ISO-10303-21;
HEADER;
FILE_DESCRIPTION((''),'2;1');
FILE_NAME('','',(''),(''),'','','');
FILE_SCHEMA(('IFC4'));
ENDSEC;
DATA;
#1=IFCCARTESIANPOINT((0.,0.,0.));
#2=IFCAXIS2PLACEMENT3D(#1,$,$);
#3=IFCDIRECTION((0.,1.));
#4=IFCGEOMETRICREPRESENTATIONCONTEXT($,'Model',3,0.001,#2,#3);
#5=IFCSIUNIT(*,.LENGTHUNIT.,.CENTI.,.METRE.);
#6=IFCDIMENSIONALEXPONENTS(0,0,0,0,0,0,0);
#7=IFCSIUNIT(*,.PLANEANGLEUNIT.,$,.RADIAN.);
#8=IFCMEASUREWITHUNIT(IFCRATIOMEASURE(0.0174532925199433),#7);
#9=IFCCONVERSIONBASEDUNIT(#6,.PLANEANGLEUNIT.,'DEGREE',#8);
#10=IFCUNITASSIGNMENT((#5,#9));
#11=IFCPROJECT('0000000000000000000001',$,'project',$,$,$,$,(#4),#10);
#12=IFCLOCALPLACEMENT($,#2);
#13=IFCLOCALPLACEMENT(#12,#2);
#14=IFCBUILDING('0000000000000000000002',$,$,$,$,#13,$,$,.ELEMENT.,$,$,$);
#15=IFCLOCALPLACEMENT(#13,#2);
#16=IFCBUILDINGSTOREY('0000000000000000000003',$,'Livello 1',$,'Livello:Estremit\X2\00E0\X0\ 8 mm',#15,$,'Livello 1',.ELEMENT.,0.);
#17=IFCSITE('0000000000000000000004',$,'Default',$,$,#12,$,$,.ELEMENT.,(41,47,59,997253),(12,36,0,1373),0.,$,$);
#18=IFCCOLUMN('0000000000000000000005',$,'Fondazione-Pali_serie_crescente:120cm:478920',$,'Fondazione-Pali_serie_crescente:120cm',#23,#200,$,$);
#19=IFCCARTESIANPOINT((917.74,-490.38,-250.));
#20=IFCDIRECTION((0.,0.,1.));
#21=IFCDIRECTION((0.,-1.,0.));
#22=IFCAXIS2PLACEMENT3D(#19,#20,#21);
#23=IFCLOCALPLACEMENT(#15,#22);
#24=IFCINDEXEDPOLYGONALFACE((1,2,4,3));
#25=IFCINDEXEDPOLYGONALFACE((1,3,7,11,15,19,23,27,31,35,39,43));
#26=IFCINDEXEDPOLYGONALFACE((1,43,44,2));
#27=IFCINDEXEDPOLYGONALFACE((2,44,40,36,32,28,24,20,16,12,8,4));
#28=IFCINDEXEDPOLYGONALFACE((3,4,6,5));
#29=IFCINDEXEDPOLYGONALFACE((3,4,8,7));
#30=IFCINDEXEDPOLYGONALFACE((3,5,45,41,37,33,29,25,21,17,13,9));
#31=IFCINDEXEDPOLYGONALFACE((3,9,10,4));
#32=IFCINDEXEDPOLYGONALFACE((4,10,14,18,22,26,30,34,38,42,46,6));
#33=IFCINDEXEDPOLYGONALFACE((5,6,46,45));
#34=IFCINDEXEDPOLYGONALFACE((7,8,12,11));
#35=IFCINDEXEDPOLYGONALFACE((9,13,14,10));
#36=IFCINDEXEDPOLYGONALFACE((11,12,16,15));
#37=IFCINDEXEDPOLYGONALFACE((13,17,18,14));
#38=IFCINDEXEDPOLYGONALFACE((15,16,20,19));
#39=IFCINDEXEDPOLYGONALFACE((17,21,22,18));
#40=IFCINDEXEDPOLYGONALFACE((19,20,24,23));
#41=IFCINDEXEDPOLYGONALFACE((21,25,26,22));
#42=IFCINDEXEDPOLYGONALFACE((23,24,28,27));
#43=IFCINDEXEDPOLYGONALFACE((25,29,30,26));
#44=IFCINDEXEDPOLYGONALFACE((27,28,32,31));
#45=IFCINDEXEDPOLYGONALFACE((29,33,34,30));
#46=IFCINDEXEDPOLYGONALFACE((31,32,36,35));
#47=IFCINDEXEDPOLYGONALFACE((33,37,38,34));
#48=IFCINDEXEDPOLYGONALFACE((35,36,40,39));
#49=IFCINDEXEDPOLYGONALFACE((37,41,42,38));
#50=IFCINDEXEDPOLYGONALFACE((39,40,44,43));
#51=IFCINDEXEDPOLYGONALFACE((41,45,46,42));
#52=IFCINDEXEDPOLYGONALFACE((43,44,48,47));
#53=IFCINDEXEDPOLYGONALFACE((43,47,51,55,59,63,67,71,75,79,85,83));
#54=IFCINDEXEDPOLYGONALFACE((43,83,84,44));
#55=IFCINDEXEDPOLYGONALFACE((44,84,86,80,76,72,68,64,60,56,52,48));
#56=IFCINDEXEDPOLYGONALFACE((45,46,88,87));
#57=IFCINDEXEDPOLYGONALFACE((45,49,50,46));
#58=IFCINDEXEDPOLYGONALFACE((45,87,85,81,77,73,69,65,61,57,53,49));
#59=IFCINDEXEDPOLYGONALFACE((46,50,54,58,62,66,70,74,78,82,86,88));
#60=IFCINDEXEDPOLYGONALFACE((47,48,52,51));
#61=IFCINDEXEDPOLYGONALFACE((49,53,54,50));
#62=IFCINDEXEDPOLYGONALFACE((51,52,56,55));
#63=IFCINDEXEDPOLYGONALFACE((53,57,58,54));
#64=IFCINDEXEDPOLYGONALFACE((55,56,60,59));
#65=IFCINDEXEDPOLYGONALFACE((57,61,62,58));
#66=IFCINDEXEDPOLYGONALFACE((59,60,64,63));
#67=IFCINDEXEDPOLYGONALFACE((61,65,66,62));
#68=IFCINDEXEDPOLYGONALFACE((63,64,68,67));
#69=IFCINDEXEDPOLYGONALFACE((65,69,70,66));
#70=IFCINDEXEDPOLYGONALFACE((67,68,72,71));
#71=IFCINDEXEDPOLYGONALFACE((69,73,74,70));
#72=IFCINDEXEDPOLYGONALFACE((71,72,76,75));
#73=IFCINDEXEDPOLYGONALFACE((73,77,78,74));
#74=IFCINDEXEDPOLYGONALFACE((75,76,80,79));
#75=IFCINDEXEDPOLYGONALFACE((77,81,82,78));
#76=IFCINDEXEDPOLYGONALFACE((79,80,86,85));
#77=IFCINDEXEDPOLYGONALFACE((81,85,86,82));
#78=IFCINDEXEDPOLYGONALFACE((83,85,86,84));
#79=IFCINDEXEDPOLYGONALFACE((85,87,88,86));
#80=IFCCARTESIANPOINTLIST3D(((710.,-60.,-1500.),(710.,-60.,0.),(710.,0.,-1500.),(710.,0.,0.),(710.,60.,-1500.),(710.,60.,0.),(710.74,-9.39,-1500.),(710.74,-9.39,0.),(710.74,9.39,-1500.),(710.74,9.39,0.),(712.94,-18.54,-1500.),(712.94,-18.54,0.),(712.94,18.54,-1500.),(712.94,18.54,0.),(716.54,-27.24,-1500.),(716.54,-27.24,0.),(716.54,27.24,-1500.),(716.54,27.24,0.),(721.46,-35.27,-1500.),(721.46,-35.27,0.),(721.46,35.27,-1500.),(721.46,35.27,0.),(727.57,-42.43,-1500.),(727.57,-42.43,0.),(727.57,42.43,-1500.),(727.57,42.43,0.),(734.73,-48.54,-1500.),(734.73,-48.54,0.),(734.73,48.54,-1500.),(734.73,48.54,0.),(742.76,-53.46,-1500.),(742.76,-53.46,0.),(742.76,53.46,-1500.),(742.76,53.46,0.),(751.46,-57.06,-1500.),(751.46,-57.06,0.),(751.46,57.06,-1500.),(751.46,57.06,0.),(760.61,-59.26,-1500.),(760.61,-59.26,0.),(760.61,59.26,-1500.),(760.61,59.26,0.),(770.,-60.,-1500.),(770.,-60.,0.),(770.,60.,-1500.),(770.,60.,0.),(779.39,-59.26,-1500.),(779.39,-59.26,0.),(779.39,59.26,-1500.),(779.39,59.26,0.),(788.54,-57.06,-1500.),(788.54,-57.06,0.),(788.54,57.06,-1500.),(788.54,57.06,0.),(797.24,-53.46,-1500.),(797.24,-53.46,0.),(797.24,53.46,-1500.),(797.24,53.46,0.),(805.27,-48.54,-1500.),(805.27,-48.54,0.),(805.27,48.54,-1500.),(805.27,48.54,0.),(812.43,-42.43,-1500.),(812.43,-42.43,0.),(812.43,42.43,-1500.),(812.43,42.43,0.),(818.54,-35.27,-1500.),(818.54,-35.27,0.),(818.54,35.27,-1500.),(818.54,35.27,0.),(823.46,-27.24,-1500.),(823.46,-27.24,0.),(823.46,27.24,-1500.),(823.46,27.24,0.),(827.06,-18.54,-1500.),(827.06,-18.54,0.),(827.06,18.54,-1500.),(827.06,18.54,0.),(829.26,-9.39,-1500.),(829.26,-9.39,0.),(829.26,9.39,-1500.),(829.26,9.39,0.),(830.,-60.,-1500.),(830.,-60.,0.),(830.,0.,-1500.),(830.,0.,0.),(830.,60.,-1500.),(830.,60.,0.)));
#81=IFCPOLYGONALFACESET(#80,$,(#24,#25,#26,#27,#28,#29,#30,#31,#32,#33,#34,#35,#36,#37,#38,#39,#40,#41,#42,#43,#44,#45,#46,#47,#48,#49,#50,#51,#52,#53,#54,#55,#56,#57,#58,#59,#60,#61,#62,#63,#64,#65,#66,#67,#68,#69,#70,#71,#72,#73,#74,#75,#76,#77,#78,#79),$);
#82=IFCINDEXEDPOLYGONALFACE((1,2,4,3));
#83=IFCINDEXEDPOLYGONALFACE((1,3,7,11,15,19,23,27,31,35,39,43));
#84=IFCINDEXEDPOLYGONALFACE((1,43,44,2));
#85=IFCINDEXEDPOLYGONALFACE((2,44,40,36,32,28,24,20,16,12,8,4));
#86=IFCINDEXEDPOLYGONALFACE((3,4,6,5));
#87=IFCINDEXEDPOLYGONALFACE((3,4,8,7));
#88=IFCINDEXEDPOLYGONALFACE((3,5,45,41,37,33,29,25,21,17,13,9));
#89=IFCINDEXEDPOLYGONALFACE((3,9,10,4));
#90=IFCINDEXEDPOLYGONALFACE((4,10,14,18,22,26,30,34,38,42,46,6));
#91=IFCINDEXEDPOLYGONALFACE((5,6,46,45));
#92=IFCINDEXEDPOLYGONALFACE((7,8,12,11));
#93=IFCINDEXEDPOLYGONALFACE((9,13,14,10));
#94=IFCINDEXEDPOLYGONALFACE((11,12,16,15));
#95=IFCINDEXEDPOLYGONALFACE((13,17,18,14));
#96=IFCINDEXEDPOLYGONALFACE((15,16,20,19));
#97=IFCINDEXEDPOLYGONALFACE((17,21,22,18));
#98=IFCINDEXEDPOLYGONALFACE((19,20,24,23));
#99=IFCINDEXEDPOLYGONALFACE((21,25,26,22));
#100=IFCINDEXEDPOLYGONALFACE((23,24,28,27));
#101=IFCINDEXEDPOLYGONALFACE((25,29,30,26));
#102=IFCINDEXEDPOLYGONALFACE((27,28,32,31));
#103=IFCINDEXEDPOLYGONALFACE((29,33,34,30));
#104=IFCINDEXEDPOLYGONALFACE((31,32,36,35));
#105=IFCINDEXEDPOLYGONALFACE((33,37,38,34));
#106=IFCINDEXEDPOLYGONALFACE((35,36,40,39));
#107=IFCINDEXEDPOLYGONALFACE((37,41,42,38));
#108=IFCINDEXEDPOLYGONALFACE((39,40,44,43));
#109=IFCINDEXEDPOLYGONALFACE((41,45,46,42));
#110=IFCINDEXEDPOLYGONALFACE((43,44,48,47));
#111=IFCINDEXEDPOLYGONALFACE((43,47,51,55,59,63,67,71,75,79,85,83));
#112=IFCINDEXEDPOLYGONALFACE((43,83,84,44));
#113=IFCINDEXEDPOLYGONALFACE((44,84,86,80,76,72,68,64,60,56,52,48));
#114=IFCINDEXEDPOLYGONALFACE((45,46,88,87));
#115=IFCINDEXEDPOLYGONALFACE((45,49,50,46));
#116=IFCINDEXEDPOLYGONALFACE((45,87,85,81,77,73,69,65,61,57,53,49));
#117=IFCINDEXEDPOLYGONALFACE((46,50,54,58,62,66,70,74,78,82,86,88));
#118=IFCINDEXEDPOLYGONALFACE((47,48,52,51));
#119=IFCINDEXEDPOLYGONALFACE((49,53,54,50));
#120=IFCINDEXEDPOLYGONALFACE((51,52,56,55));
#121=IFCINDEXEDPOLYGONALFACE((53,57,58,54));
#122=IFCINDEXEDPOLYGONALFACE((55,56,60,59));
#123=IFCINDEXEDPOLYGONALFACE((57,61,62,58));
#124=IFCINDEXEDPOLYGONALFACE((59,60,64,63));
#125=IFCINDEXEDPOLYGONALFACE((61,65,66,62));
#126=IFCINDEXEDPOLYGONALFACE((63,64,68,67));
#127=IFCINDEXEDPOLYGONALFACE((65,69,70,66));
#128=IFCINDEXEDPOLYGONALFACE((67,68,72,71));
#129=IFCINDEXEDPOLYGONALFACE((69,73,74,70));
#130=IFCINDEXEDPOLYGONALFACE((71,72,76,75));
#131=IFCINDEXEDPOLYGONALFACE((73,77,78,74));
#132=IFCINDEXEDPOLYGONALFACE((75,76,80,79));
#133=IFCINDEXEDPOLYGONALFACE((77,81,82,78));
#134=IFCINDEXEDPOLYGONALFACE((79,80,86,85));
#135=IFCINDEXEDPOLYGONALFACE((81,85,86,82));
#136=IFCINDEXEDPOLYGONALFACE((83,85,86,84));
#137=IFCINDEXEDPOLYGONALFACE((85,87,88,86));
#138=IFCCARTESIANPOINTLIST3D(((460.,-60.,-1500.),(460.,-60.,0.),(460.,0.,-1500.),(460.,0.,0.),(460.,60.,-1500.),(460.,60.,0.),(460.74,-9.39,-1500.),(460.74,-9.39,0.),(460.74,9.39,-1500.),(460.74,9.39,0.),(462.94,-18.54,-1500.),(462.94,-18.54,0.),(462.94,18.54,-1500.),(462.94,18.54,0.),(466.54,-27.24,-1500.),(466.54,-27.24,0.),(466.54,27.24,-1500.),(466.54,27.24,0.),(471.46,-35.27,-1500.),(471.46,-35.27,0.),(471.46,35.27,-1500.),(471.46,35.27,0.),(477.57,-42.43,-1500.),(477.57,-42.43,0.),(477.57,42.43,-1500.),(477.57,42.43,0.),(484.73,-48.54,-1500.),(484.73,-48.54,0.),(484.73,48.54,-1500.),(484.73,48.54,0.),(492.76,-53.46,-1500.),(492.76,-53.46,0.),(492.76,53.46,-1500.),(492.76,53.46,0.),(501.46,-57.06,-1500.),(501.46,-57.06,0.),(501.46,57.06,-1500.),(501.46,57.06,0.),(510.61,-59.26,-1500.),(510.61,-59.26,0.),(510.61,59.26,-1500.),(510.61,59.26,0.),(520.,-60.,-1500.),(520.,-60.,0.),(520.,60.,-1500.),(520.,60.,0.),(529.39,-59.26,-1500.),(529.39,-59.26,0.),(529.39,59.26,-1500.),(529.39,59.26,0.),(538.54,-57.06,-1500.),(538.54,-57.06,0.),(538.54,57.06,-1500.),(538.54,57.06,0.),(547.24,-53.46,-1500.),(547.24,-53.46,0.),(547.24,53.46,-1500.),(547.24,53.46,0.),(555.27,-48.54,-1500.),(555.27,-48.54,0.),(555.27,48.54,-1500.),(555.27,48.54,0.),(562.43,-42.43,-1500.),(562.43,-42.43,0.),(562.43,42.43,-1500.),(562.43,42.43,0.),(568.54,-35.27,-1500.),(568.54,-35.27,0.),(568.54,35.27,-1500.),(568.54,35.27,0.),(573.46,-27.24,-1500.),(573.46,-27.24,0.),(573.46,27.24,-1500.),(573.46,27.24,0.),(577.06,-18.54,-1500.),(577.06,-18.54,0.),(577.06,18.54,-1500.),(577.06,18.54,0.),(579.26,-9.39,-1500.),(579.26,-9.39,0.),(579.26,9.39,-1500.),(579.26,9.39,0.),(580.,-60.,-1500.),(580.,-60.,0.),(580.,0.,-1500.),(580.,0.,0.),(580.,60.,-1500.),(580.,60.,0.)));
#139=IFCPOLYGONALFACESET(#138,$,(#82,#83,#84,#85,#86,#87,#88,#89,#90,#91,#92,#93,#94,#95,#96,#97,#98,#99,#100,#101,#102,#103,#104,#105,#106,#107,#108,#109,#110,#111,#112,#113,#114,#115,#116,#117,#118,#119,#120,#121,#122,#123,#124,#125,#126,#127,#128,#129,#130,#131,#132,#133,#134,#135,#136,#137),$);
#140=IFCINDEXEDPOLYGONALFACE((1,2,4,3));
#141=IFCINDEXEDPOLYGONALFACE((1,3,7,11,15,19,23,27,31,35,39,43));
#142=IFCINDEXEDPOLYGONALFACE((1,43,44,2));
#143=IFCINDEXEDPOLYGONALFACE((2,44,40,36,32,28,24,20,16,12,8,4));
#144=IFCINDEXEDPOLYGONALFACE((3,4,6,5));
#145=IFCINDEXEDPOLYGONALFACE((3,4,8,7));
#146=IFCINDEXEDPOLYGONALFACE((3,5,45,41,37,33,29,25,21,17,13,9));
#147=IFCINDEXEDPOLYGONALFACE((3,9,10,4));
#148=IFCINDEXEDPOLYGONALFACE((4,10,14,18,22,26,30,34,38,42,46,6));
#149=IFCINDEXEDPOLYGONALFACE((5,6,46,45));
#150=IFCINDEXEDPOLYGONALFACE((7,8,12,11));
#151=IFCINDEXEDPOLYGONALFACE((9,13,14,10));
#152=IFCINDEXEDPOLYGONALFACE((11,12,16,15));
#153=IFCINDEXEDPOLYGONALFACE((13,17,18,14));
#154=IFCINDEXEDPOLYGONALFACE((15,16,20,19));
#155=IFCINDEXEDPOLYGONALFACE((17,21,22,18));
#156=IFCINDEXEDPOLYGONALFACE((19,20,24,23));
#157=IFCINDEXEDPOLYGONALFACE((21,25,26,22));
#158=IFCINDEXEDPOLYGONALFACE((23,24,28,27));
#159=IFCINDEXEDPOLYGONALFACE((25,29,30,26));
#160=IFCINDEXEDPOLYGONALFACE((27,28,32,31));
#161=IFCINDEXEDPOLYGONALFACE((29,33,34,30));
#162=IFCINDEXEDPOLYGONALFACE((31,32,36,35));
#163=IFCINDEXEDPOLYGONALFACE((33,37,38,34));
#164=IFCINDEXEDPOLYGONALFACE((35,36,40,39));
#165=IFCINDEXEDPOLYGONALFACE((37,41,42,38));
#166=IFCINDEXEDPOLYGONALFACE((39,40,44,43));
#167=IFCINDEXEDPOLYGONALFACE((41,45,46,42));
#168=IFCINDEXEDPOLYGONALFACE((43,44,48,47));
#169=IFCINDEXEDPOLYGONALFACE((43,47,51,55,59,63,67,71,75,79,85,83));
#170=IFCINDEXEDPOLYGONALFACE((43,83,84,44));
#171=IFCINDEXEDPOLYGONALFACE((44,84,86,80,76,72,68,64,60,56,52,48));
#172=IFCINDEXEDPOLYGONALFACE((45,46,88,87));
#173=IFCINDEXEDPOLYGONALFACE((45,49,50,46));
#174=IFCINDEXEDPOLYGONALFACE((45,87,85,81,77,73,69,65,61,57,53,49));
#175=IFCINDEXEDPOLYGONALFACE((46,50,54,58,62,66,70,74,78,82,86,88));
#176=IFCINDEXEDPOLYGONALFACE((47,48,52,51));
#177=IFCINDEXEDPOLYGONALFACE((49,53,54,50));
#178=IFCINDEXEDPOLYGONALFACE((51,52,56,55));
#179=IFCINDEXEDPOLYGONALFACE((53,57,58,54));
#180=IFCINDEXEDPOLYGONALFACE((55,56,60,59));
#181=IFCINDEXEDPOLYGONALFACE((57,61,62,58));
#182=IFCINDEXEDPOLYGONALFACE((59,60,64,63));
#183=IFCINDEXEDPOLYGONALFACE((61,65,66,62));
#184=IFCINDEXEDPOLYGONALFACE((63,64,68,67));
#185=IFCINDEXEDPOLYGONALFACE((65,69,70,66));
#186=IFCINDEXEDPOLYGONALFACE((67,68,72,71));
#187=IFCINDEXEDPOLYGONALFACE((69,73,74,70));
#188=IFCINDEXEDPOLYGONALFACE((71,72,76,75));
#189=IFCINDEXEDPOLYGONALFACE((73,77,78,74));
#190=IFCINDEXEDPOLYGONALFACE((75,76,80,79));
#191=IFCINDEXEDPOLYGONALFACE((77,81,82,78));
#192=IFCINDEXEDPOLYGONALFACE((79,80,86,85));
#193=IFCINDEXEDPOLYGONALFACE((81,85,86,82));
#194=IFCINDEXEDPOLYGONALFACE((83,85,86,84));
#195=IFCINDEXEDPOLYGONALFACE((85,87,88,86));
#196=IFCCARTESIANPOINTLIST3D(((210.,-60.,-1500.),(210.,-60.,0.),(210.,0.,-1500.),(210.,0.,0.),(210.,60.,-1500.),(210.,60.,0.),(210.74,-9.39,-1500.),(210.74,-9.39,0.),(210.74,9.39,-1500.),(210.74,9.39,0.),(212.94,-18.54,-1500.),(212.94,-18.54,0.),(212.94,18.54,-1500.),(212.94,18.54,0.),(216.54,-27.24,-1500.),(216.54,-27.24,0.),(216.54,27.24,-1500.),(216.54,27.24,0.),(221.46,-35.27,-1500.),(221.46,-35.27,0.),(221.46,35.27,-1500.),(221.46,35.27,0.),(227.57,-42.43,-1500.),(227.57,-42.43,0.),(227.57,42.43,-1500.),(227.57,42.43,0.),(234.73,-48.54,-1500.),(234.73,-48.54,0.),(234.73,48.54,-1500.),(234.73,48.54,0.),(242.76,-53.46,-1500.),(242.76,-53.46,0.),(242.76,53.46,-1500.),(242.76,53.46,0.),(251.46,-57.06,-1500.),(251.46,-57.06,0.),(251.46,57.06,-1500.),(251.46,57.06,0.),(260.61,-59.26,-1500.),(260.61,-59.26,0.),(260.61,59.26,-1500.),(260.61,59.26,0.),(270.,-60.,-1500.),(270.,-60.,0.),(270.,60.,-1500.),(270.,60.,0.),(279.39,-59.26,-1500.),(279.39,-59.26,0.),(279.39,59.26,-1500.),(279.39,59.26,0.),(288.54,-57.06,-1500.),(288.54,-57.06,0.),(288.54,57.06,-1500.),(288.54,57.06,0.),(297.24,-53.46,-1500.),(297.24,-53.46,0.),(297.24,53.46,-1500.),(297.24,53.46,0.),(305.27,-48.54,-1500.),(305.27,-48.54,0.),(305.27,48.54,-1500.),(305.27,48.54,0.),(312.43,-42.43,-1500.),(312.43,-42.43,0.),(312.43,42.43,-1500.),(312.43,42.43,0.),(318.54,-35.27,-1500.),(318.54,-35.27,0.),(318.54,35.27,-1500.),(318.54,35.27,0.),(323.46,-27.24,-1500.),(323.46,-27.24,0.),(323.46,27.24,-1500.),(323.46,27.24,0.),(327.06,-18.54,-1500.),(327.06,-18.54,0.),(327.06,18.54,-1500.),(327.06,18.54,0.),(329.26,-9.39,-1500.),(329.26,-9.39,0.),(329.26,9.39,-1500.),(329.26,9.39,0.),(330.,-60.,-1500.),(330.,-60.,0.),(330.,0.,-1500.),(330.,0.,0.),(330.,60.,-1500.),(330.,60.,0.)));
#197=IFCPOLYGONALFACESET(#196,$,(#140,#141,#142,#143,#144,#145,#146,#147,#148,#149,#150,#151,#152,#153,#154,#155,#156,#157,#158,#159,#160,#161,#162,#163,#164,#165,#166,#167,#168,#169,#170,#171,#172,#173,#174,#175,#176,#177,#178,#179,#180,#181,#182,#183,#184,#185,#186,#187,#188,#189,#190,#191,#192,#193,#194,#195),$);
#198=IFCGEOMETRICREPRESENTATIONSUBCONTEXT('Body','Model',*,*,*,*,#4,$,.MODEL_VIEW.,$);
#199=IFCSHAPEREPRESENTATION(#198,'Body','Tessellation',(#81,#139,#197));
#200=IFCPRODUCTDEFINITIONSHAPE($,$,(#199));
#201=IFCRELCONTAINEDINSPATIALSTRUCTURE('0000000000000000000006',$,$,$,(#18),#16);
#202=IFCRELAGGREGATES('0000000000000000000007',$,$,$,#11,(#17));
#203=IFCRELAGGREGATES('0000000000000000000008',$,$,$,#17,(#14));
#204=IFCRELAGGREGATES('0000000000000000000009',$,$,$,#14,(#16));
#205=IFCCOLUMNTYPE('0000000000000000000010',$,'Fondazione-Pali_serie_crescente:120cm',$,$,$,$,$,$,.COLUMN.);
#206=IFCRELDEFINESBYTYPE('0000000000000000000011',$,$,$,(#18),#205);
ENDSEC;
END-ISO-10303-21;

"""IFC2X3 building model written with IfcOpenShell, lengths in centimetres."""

from ifc_helpers import new_model, entity, si_unit, converted_unit, direction, frame, frame_2d, origin, origin_2d_with_axis, place, context, subcontext, project, spatial, rectangle, circle, extrude, boolean, source, transform, mapped, type_object, type_shapes, element, save


model = new_model("IFC2X3")

# Units and contexts
model_context = context("Model", 3, precision=0.001, world=origin(), true_north=direction((0.0, 1.0)))
body_context = subcontext(model_context, "Body", "Model", "MODEL_VIEW")
ifc_project = project(units=[si_unit("LENGTHUNIT", "METRE", prefix="CENTI"), converted_unit("PLANEANGLEUNIT", "DEGREE", entity("IfcRatioMeasure", 0.0174532925199433), si_unit("PLANEANGLEUNIT", "RADIAN"), dimensions=[0, 0, 0, 0, 0, 0, 0])], contexts=[model_context])

# Site, building, storey
site_placement = place(None, origin())
site = spatial("IfcSite", under=ifc_project, at=site_placement, Name="Default", CompositionType="ELEMENT", RefLatitude=(41, 47, 59, 997253), RefLongitude=(12, 36, 0, 1373), RefElevation=0.0)
building_placement = place(site_placement, origin())
building = spatial("IfcBuilding", under=site, at=building_placement, CompositionType="ELEMENT")
storey_placement = place(building_placement, origin())
storey = spatial("IfcBuildingStorey", under=building, at=storey_placement, Name="Livello 1", ObjectType="Livello:Estremità 8 mm", LongName="Livello 1", CompositionType="ELEMENT", Elevation=0.0)

# Column
column_type_1 = type_object("IfcColumnType", Name="Fondazione-Pali_serie_crescente:120cm", PredefinedType="COLUMN")
shared_shape_1 = source(origin(), body_context, "Body", "SweptSolid", [
    boolean("DIFFERENCE", extrude(rectangle(XDim=1500.0, YDim=120.0, at=origin_2d_with_axis()), frame((710.0, 0.0, -750.0), z_axis=(1.0, 0.0, 0.0), x_axis=(0.0, 0.0, -1.0)), (0.0, 0.0, 1.0), 120.0), extrude(circle(Radius=60.0, at=frame_2d((0.0, 0.0), x_axis=(1.0, 0.0))), frame((770.0, 0.0, 0.0)), (0.0, 0.0, -1.0), 1500.0)),
    boolean("DIFFERENCE", extrude(rectangle(XDim=1500.0, YDim=120.0, at=origin_2d_with_axis()), frame((460.0, 0.0, -750.0), z_axis=(1.0, 0.0, 0.0), x_axis=(0.0, 0.0, -1.0)), (0.0, 0.0, 1.0), 120.0), extrude(circle(Radius=60.0, at=frame_2d((0.0, 0.0), x_axis=(1.0, 0.0))), frame((520.0, 0.0, 0.0)), (0.0, 0.0, -1.0), 1500.0)),
    boolean("DIFFERENCE", extrude(rectangle(XDim=1500.0, YDim=120.0, at=origin_2d_with_axis()), frame((210.0, 0.0, -750.0), z_axis=(1.0, 0.0, 0.0), x_axis=(0.0, 0.0, -1.0)), (0.0, 0.0, 1.0), 120.0), extrude(circle(Radius=60.0, at=frame_2d((0.0, 0.0), x_axis=(1.0, 0.0))), frame((270.0, 0.0, 0.0)), (0.0, 0.0, -1.0), 1500.0)),
])
type_shapes(column_type_1, [shared_shape_1])
for number, where, z_axis, x_axis, name in (
    (1, (917.74, -490.38, -250.0), (0.0, 0.0, 1.0), (0.0, -1.0, 0.0), "Fondazione-Pali_serie_crescente:120cm:478920"),
):
    element("IfcColumn", number, at=place(storey_placement, frame(where, z_axis=z_axis, x_axis=x_axis)), inside=storey, type_object=column_type_1, Name=name, ObjectType="Fondazione-Pali_serie_crescente:120cm", context=body_context, shape_type="MappedRepresentation", body=[
        mapped(shared_shape_1, transform((0.0, 0.0, 0.0), scale=1.0)),
    ])

save(model, "model.ifc")
